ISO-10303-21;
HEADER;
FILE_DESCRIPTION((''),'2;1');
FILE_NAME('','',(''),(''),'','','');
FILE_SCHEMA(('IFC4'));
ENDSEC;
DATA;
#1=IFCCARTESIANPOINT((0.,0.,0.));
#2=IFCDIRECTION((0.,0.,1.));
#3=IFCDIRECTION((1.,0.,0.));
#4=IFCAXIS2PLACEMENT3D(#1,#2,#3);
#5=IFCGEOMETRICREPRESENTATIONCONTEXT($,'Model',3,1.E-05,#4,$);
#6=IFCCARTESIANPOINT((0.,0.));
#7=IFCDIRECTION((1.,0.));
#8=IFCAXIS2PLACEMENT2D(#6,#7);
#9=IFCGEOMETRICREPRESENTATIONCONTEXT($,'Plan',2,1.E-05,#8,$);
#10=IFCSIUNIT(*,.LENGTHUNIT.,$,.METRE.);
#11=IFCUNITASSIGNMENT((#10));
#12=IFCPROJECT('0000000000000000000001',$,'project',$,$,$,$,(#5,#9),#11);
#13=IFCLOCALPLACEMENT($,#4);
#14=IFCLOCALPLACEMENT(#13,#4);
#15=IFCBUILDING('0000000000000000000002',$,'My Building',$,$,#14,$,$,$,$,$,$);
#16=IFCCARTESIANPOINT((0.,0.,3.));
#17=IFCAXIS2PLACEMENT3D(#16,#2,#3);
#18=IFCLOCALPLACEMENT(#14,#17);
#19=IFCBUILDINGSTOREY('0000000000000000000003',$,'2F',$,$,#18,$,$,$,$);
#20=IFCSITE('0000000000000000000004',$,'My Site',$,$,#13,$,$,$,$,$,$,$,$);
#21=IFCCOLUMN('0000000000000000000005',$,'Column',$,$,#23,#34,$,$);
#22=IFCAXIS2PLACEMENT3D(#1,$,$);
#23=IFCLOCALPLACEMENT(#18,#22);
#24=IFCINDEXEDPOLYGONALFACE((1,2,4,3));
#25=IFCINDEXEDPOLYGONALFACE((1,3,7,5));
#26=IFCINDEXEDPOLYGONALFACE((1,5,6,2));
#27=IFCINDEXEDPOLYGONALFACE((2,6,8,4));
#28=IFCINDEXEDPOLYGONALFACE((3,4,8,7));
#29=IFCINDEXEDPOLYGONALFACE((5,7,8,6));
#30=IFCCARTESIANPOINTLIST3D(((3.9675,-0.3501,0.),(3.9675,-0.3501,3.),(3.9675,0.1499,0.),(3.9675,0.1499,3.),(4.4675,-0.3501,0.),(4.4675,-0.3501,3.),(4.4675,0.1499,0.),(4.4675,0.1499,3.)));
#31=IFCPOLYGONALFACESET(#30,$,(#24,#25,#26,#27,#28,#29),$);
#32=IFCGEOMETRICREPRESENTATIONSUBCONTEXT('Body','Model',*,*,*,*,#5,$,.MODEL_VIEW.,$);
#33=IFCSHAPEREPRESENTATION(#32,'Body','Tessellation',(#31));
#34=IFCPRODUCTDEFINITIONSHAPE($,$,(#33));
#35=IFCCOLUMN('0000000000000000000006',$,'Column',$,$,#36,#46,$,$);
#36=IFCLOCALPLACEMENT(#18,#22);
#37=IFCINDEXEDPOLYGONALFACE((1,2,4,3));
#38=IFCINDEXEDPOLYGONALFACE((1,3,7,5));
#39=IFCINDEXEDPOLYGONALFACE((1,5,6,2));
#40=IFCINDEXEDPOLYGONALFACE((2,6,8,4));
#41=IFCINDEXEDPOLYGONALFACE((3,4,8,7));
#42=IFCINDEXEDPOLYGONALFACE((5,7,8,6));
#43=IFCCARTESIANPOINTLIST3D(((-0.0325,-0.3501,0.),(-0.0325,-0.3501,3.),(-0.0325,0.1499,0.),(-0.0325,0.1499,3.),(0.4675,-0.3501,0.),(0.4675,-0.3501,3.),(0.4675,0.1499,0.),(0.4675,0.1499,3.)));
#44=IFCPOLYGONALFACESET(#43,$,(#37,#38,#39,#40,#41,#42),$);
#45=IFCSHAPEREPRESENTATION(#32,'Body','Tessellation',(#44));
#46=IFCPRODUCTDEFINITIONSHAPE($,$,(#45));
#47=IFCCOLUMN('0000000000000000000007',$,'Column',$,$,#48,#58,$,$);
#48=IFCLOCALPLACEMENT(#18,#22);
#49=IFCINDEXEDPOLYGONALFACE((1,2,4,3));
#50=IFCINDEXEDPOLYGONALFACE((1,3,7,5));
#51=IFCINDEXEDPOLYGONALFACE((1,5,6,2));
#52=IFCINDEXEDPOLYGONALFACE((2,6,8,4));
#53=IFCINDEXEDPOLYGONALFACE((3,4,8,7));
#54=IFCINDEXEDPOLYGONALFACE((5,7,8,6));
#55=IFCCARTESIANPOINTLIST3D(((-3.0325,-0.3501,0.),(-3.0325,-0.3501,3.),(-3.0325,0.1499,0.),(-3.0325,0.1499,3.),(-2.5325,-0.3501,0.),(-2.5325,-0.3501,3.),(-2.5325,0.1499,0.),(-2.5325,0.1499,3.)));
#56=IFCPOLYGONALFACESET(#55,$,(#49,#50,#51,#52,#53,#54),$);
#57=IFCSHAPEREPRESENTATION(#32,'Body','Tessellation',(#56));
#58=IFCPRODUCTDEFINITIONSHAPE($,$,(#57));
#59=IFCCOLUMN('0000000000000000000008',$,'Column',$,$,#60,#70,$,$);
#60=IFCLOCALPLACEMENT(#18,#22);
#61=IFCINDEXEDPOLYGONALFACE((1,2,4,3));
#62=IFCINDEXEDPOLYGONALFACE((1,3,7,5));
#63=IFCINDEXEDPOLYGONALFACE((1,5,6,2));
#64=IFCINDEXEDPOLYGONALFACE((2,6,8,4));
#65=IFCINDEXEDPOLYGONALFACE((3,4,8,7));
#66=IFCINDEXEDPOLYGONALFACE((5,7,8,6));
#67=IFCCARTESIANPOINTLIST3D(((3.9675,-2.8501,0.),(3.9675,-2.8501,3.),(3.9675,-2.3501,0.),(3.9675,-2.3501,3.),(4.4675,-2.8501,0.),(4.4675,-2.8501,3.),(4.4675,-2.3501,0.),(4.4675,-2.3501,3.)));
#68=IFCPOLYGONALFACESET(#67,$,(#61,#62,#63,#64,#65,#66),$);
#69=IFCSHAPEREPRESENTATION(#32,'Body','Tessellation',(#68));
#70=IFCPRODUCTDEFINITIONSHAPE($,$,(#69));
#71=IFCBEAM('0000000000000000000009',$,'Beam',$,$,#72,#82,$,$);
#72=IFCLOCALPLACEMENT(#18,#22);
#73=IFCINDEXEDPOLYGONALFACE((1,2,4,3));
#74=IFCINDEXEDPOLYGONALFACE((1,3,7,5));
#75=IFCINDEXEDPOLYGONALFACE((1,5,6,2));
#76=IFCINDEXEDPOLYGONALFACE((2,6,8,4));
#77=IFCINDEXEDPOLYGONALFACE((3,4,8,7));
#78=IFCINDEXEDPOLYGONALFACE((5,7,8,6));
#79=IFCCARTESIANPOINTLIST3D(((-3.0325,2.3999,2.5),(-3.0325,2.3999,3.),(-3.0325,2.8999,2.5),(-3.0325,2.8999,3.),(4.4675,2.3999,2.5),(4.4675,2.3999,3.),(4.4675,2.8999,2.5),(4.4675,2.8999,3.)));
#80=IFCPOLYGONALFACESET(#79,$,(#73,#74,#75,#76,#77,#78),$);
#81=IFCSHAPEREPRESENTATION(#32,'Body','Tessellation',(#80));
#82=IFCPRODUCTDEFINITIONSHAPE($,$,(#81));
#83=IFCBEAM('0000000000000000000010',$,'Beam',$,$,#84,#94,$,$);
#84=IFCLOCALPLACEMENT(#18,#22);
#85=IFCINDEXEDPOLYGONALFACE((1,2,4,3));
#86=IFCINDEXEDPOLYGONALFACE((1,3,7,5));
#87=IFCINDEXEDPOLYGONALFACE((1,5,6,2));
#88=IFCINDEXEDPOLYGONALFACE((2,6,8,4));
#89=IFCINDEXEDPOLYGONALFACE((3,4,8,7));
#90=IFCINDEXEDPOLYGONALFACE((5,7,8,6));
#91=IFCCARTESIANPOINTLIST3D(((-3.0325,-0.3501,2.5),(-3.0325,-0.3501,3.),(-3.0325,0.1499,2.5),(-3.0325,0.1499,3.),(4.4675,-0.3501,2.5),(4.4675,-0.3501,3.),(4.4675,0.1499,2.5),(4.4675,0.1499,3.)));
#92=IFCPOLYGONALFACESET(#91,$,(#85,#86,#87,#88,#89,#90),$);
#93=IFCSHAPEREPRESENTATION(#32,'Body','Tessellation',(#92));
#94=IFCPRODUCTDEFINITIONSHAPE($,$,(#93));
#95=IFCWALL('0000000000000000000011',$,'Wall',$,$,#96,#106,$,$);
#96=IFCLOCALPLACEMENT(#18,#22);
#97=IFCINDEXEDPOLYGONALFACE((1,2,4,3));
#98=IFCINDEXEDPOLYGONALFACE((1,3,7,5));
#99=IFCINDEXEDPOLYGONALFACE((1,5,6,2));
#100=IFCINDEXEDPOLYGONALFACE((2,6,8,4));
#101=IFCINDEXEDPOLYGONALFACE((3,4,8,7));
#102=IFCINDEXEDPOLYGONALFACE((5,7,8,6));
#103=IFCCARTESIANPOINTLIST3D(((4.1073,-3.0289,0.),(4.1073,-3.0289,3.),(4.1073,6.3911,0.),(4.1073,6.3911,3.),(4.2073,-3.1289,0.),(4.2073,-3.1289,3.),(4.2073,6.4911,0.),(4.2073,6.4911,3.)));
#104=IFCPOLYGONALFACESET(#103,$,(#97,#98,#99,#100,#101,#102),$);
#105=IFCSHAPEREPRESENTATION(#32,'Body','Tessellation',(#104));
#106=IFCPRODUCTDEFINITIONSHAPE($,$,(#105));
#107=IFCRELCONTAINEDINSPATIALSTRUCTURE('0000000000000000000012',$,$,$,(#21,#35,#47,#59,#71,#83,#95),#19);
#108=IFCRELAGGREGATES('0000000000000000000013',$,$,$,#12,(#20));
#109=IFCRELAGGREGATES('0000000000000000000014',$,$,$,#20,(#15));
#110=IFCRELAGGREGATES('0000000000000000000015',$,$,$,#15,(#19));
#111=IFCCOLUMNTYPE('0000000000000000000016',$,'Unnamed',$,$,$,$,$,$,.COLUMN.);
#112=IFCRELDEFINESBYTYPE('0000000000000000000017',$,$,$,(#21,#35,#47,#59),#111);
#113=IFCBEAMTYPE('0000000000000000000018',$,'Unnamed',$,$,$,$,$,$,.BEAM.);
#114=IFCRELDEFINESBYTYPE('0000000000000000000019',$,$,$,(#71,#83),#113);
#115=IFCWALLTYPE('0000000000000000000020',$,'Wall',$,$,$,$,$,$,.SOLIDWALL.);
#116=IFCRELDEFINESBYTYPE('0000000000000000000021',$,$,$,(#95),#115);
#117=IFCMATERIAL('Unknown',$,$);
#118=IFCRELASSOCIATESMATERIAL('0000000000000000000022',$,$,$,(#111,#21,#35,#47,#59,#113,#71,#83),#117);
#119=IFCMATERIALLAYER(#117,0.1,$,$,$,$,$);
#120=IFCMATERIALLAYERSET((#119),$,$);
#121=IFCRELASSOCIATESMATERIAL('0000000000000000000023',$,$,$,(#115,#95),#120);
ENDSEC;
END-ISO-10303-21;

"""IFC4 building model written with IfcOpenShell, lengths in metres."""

from ifc_helpers import new_model, si_unit, frame, origin_with_axes, origin_2d_with_axis, place, context, subcontext, project, spatial, line, indexed_curve, rectangle, outline, extrude, material, layer, layer_set, layer_usage, material_profile, profile_set, profile_usage, type_object, element, save


model = new_model("IFC4")

# Units and contexts
model_context = context("Model", 3, precision=1e-05, world=origin_with_axes())
plan_context = context("Plan", 2, precision=1e-05, world=origin_2d_with_axis())
body_context_1 = subcontext(model_context, "Body", "Model", "MODEL_VIEW")
ifc_project = project(units=[si_unit("LENGTHUNIT", "METRE")], contexts=[model_context, plan_context])

# Site, building, storey
site_placement = place(None, origin_with_axes())
site = spatial("IfcSite", under=ifc_project, at=site_placement, Name="My Site")
building_placement = place(site_placement, origin_with_axes())
building = spatial("IfcBuilding", under=site, at=building_placement, Name="My Building")
storey_placement = place(building_placement, frame((0.0, 0.0, 3.0), z_axis=(0.0, 0.0, 1.0), x_axis=(1.0, 0.0, 0.0)))
storey = spatial("IfcBuildingStorey", under=building, at=storey_placement, Name="2F")

# Columns
ifc_material = material(Name="Unknown")
ifc_material_profile_1 = material_profile(ifc_material, rectangle(XDim=0.5, YDim=0.5))
ifc_profile_set_1 = profile_set([ifc_material_profile_1])
ifc_profile_usage_1 = profile_usage(ifc_profile_set_1, cardinal=5)
column_type = type_object("IfcColumnType", Name="Unnamed", PredefinedType="COLUMN", material=ifc_profile_set_1)
column_1_placement = place(storey_placement, frame((4.2175, -0.1001, 0.0), z_axis=(0.0, 0.0, 1.0), x_axis=(1.0, 0.0, 0.0)))
element("IfcColumn", 1, at=column_1_placement, inside=storey, type_object=column_type, material=ifc_profile_usage_1, Name="Column", context=body_context_1, shape_type="SweptSolid", body=[
    extrude(rectangle(XDim=0.5, YDim=0.5), origin_with_axes(), (0.0, 0.0, 1.0), 3.0),
])
ifc_profile_usage_2 = profile_usage(ifc_profile_set_1, cardinal=5)
column_2_placement = place(storey_placement, frame((0.2175, -0.1001, 0.0), z_axis=(0.0, 0.0, 1.0), x_axis=(1.0, 0.0, 0.0)))
element("IfcColumn", 2, at=column_2_placement, inside=storey, type_object=column_type, material=ifc_profile_usage_2, Name="Column", context=body_context_1, shape_type="SweptSolid", body=[
    extrude(rectangle(XDim=0.5, YDim=0.5), origin_with_axes(), (0.0, 0.0, 1.0), 3.0),
])
ifc_profile_usage_3 = profile_usage(ifc_profile_set_1, cardinal=5)
column_3_placement = place(storey_placement, frame((-2.7825, -0.1001, 0.0), z_axis=(0.0, 0.0, 1.0), x_axis=(1.0, 0.0, 0.0)))
element("IfcColumn", 3, at=column_3_placement, inside=storey, type_object=column_type, material=ifc_profile_usage_3, Name="Column", context=body_context_1, shape_type="SweptSolid", body=[
    extrude(rectangle(XDim=0.5, YDim=0.5), origin_with_axes(), (0.0, 0.0, 1.0), 3.0),
])
ifc_profile_usage_4 = profile_usage(ifc_profile_set_1, cardinal=5)
column_4_placement = place(storey_placement, frame((4.2175, -2.6001, 0.0), z_axis=(0.0, 0.0, 1.0), x_axis=(1.0, 0.0, 0.0)))
element("IfcColumn", 4, at=column_4_placement, inside=storey, type_object=column_type, material=ifc_profile_usage_4, Name="Column", context=body_context_1, shape_type="SweptSolid", body=[
    extrude(rectangle(XDim=0.5, YDim=0.5), origin_with_axes(), (0.0, 0.0, 1.0), 3.0),
])

# Beams
ifc_material_profile_2 = material_profile(ifc_material, rectangle(XDim=0.5, YDim=0.5))
ifc_profile_set_2 = profile_set([ifc_material_profile_2])
ifc_profile_usage_5 = profile_usage(ifc_profile_set_2, cardinal=7)
beam_type = type_object("IfcBeamType", Name="Unnamed", PredefinedType="BEAM", material=ifc_profile_set_2)
beam_1_placement = place(storey_placement, frame((4.4675, 2.3999, 3.0), z_axis=(-1.0, 0.0, 0.0), x_axis=(0.0, -1.0, 0.0)))
element("IfcBeam", 5, at=beam_1_placement, inside=storey, type_object=beam_type, material=ifc_profile_usage_5, Name="Beam", context=body_context_1, shape_type="SweptSolid", body=[
    extrude(rectangle(XDim=0.5, YDim=0.5), frame((-0.25, -0.25, 0.0), z_axis=(0.0, 0.0, 1.0), x_axis=(1.0, 0.0, 0.0)), (0.0, 0.0, 1.0), 7.5),
])
ifc_profile_usage_6 = profile_usage(ifc_profile_set_2, cardinal=7)
beam_2_placement = place(storey_placement, frame((4.4675, -0.3501, 3.0), z_axis=(-1.0, 0.0, 0.0), x_axis=(0.0, -1.0, 0.0)))
element("IfcBeam", 6, at=beam_2_placement, inside=storey, type_object=beam_type, material=ifc_profile_usage_6, Name="Beam", context=body_context_1, shape_type="SweptSolid", body=[
    extrude(rectangle(XDim=0.5, YDim=0.5), frame((-0.25, -0.25, 0.0), z_axis=(0.0, 0.0, 1.0), x_axis=(1.0, 0.0, 0.0)), (0.0, 0.0, 1.0), 7.5),
])

# Wall
ifc_layer_1 = layer(ifc_material, 0.1)
ifc_layer_set_1 = layer_set([ifc_layer_1])
ifc_layer_usage_1 = layer_usage(ifc_layer_set_1, "AXIS2", "POSITIVE", 0.0)
wall_type_1 = type_object("IfcWallType", Name="Wall", PredefinedType="SOLIDWALL", material=ifc_layer_set_1)
wall_1_placement = place(storey_placement, frame((4.2073, -3.1289, 0.0), z_axis=(0.0, 0.0, 1.0), x_axis=(0.0, 1.0, 0.0)))
element("IfcWall", 7, at=wall_1_placement, inside=storey, type_object=wall_type_1, material=ifc_layer_usage_1, Name="Wall", context=body_context_1, shape_type="SweptSolid", body=[
    extrude(outline(indexed_curve([(0.0, 0.0), (0.1, 0.1), (9.52, 0.1), (9.62, 0.0)], segments=[line(1, 2, 3, 4, 1)])), origin_with_axes(), (0.0, 0.0, 1.0), 3.0),
])

save(model, "model.ifc")
